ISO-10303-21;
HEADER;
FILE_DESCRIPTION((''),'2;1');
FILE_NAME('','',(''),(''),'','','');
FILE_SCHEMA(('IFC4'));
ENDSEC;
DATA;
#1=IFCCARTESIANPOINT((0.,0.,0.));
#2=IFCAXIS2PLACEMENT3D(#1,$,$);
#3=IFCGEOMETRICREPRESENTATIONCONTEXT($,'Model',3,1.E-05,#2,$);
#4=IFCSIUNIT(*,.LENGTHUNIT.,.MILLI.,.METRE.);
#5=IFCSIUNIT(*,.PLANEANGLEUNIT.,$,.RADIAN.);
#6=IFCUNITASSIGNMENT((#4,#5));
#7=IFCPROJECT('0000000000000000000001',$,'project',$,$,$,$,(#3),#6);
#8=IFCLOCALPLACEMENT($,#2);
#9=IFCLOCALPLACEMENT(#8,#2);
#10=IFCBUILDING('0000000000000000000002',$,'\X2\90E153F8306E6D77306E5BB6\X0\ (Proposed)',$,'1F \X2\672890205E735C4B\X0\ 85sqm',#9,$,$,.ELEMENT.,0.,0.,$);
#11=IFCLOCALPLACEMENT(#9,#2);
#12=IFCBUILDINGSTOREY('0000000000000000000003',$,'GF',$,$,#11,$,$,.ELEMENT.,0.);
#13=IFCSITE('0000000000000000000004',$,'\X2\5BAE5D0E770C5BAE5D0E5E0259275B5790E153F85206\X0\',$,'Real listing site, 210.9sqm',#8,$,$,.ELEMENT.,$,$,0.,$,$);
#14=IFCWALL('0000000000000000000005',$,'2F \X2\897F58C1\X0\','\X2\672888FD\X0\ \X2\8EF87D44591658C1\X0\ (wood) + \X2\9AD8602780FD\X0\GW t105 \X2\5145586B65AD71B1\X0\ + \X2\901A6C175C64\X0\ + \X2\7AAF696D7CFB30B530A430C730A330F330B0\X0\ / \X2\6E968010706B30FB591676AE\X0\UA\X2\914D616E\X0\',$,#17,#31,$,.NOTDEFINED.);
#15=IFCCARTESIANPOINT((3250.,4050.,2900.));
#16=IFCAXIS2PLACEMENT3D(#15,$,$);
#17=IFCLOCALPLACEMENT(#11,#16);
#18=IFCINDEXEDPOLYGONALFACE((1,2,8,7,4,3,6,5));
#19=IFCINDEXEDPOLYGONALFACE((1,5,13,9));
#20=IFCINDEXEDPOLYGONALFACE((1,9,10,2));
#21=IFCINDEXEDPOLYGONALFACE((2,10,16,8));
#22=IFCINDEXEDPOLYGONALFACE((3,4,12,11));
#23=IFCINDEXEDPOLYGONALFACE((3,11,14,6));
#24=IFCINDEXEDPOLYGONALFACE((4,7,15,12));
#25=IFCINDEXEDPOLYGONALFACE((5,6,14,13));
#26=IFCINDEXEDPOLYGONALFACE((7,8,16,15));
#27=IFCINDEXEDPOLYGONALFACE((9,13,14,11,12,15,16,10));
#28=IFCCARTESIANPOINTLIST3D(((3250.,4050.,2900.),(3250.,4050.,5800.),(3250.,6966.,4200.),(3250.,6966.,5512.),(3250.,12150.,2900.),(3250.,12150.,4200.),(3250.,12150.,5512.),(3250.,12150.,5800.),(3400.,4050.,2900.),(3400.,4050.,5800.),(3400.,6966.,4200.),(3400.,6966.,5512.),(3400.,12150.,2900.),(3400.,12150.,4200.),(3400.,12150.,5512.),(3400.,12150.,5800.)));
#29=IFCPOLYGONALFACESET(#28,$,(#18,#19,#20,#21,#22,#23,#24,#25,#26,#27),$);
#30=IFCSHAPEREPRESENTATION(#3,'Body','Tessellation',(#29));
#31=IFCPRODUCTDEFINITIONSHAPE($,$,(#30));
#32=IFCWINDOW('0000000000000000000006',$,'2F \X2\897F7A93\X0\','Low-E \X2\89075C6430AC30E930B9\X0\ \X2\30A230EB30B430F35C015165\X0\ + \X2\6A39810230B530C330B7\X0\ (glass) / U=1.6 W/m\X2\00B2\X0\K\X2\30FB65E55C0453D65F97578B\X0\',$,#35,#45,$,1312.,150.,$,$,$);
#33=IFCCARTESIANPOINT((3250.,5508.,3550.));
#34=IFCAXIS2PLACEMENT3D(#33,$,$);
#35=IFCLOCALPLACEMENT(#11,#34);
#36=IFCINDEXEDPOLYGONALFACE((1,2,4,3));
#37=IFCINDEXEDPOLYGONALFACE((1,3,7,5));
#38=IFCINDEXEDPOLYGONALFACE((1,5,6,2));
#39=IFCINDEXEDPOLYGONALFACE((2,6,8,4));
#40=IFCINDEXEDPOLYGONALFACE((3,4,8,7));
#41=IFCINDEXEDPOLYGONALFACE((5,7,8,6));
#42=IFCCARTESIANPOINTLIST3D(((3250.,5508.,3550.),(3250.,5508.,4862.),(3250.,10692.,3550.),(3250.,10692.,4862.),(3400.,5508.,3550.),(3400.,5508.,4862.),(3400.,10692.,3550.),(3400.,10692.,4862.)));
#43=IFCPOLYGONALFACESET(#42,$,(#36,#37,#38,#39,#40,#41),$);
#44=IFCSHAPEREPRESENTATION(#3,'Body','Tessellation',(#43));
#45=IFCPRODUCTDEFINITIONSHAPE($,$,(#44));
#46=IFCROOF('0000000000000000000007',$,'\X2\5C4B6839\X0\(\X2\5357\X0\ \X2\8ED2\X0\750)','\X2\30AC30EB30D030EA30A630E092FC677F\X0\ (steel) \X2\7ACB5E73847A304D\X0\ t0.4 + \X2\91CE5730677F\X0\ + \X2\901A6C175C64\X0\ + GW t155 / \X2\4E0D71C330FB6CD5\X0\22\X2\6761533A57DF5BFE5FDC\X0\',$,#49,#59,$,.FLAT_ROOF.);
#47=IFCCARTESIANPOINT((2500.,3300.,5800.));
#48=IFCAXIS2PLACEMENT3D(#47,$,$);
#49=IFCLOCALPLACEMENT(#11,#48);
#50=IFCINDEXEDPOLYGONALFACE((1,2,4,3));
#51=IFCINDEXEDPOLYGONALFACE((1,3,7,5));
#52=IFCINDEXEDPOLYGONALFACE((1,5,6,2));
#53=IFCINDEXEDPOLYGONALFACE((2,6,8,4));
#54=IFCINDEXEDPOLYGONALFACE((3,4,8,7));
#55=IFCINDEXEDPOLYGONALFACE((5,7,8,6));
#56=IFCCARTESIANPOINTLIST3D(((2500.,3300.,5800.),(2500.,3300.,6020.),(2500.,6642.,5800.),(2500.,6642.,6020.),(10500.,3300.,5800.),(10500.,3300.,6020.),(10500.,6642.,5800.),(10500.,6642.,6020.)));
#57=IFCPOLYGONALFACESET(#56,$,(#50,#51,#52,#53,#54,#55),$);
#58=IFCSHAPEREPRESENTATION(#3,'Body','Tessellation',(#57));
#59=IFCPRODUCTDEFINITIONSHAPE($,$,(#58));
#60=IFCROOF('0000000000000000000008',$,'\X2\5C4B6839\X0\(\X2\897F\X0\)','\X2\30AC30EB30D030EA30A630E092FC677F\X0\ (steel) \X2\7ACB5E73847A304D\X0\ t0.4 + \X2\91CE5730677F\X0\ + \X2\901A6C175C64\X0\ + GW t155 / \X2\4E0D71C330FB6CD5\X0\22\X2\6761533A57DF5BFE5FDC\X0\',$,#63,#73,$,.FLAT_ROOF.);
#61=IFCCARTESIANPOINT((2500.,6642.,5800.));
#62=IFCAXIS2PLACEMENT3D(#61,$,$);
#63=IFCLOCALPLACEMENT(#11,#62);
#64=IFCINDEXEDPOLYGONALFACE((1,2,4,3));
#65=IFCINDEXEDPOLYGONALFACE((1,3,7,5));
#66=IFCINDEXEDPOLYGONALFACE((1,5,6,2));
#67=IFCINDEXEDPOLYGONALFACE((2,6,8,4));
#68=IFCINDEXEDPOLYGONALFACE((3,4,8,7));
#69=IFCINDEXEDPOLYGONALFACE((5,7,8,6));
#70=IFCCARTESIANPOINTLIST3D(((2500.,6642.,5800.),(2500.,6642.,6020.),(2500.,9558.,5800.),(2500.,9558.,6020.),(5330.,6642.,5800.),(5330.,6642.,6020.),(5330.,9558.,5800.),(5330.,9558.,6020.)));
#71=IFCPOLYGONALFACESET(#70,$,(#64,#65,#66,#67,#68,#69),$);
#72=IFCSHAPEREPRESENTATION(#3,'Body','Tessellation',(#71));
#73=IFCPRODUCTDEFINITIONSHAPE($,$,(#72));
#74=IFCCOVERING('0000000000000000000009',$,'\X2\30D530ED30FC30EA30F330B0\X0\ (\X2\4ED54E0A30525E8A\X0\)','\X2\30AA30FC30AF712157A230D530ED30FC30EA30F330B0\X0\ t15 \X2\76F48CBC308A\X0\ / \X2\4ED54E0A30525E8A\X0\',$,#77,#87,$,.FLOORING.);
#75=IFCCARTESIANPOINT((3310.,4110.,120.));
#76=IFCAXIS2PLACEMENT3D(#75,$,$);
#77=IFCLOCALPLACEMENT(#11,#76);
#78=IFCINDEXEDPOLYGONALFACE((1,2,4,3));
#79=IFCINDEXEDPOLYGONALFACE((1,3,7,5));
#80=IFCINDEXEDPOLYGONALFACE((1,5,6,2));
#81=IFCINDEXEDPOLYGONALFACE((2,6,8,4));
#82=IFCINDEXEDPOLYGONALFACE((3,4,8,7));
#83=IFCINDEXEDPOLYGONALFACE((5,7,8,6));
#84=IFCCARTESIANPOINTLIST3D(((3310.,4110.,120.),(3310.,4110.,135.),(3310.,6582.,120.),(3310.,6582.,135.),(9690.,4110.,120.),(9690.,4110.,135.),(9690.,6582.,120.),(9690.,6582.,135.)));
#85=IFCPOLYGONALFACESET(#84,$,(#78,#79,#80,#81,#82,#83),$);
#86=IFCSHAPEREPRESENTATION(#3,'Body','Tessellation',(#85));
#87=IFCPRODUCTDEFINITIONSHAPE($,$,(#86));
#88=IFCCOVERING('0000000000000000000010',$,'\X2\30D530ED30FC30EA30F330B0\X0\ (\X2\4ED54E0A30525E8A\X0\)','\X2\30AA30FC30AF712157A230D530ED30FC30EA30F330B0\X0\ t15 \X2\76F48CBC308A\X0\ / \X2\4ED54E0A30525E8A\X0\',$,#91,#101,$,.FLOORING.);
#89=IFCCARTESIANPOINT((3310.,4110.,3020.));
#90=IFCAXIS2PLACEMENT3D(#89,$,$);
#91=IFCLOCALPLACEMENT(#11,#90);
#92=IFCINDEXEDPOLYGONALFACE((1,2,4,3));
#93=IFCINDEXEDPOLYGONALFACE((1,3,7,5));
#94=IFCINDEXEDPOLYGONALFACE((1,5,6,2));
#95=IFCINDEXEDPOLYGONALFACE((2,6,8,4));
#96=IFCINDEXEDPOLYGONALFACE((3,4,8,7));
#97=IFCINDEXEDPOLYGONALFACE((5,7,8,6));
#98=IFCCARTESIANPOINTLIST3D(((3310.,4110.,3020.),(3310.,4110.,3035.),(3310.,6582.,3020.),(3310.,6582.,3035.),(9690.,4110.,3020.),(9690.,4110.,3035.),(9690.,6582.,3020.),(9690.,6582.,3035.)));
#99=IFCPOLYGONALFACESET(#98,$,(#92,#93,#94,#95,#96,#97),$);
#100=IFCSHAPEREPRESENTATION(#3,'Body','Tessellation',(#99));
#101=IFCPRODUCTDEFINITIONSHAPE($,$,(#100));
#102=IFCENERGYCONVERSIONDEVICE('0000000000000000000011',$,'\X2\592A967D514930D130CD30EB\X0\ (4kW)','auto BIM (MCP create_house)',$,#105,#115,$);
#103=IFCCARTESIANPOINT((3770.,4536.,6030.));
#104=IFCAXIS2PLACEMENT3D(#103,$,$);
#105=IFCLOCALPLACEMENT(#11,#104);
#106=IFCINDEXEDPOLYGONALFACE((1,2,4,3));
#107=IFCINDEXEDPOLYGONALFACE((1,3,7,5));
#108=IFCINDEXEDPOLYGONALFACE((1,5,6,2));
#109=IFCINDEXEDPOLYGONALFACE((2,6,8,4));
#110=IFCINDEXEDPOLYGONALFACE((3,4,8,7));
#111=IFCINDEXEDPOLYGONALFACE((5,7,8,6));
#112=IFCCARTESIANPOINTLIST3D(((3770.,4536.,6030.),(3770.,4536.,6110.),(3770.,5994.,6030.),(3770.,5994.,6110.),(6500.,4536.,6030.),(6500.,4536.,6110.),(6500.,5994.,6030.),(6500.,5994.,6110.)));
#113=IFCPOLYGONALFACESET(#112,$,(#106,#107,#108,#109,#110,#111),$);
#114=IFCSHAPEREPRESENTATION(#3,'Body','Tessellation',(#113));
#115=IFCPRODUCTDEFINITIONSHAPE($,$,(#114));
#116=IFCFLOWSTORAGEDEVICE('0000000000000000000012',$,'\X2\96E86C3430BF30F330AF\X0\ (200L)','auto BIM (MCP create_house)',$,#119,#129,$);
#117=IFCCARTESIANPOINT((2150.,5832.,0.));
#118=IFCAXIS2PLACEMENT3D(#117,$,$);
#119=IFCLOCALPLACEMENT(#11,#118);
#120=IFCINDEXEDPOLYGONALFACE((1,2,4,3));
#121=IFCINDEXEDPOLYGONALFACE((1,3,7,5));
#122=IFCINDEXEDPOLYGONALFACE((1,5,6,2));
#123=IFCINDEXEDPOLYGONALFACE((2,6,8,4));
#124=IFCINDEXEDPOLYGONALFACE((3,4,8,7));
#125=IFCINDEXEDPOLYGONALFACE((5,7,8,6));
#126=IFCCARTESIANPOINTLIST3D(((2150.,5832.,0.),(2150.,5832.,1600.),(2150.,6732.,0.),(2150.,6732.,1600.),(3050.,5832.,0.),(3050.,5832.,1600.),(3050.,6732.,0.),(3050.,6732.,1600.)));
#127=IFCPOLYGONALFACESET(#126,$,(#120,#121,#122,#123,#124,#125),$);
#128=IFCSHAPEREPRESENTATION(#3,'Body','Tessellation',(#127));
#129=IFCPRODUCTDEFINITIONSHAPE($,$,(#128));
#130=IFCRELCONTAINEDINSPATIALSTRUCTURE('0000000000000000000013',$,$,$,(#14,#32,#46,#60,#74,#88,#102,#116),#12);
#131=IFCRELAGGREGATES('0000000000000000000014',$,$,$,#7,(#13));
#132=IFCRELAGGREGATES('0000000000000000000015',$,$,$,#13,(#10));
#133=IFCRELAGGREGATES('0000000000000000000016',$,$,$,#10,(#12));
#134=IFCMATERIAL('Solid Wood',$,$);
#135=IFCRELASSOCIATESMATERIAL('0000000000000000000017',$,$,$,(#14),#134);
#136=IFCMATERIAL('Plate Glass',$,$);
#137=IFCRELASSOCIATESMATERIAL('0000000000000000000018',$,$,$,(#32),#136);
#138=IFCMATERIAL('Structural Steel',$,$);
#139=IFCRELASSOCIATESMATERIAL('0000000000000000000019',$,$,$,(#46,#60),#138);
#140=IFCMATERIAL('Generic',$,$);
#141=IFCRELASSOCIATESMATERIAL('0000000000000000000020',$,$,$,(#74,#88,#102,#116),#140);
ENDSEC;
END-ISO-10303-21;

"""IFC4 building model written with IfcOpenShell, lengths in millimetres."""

from ifc_helpers import new_model, si_unit, frame, frame_2d, origin, place, context, project, spatial, rectangle, extrude, material, element, fill, save


model = new_model("IFC4")

# Units and contexts
model_context = context("Model", 3, precision=1e-05, world=origin())
ifc_project = project(units=[si_unit("LENGTHUNIT", "METRE", prefix="MILLI"), si_unit("PLANEANGLEUNIT", "RADIAN")], contexts=[model_context])

# Site, building, storey
site_placement = place(None, origin())
site = spatial("IfcSite", under=ifc_project, at=site_placement, Name="宮崎県宮崎市大字郡司分", ObjectType="Real listing site, 210.9sqm", CompositionType="ELEMENT", RefElevation=0.0)
building_placement = place(site_placement, origin())
building = spatial("IfcBuilding", under=site, at=building_placement, Name="郡司の海の家 (Proposed)", ObjectType="1F 木造平屋 85sqm", CompositionType="ELEMENT", ElevationOfRefHeight=0.0, ElevationOfTerrain=0.0)
storey_placement = place(building_placement, origin())
storey = spatial("IfcBuildingStorey", under=building, at=storey_placement, Name="GF", CompositionType="ELEMENT", Elevation=0.0)

# Shared definitions
ifc_material_1 = material(Name="Solid Wood")
ifc_material_2 = material(Name="Generic")

# Shared definitions
ifc_material_3 = material(Name="Plate Glass")

# Wall, opening, window
wall_1_placement = place(storey_placement, frame((3250.0, 4050.0, 2900.0)))
wall_1 = element("IfcWall", 1, at=wall_1_placement, inside=storey, material=ifc_material_1, Name="2F 西壁", Description="木製 軸組外壁 (wood) + 高性能GW t105 充填断熱 + 通気層 + 窯業系サイディング / 準耐火・外皮UA配慮", PredefinedType="NOTDEFINED", context=model_context, shape_type="SweptSolid", body=[
    extrude(rectangle(XDim=150.0, YDim=8100.0, at=frame_2d((75.0, 4050.0))), frame((3250.0, 4050.0, 2900.0)), (0.0, 0.0, 1.0), 2900.0),
])
opening_1_placement = place(storey_placement, frame((3250.0, 5508.0, 3550.0)))
opening_1 = element("IfcOpeningElement", 2, at=opening_1_placement, cuts=wall_1, PredefinedType="NOTDEFINED", context=model_context, shape_type="SweptSolid", body=[
    extrude(rectangle(XDim=150.0, YDim=5184.0, at=frame_2d((75.0, 2592.0))), frame((3250.0, 5508.0, 3550.0)), (0.0, 0.0, 1.0), 1312.0),
])
window_1_placement = place(storey_placement, frame((3250.0, 5508.0, 3550.0)))
window_1 = element("IfcWindow", 3, at=window_1_placement, inside=storey, material=ifc_material_3, Name="2F 西窓", Description="Low-E 複層ガラス アルゴン封入 + 樹脂サッシ (glass) / U=1.6 W/m²K・日射取得型", OverallHeight=1312.0, OverallWidth=150.0, context=model_context, shape_type="SweptSolid", body=[
    extrude(rectangle(XDim=150.0, YDim=5184.0, at=frame_2d((75.0, 2592.0))), frame((3250.0, 5508.0, 3550.0)), (0.0, 0.0, 1.0), 1312.0),
])
fill(opening_1, window_1)

# Roofs
ifc_material_4 = material(Name="Structural Steel")
roof_1_placement = place(storey_placement, frame((2500.0, 3300.0, 5800.0)))
element("IfcRoof", 4, at=roof_1_placement, inside=storey, material=ifc_material_4, Name="屋根(南 軒750)", Description="ガルバリウム鋼板 (steel) 立平葺き t0.4 + 野地板 + 通気層 + GW t155 / 不燃・法22条区域対応", PredefinedType="FLAT_ROOF", context=model_context, shape_type="SweptSolid", body=[
    extrude(rectangle(XDim=8000.0, YDim=3342.0, at=frame_2d((4000.0, 1671.0))), frame((2500.0, 3300.0, 5800.0)), (0.0, 0.0, 1.0), 220.0),
])
roof_2_placement = place(storey_placement, frame((2500.0, 6642.0, 5800.0)))
element("IfcRoof", 5, at=roof_2_placement, inside=storey, material=ifc_material_4, Name="屋根(西)", Description="ガルバリウム鋼板 (steel) 立平葺き t0.4 + 野地板 + 通気層 + GW t155 / 不燃・法22条区域対応", PredefinedType="FLAT_ROOF", context=model_context, shape_type="SweptSolid", body=[
    extrude(rectangle(XDim=2830.0, YDim=2916.0, at=frame_2d((1415.0, 1458.0))), frame((2500.0, 6642.0, 5800.0)), (0.0, 0.0, 1.0), 220.0),
])

# Coverings
covering_1_placement = place(storey_placement, frame((3310.0, 4110.0, 120.0)))
element("IfcCovering", 6, at=covering_1_placement, inside=storey, material=ifc_material_2, Name="フローリング (仕上げ床)", Description="オーク無垢フローリング t15 直貼り / 仕上げ床", PredefinedType="FLOORING", context=model_context, shape_type="SweptSolid", body=[
    extrude(rectangle(XDim=6380.0, YDim=2472.0, at=frame_2d((3190.0, 1236.0))), frame((3310.0, 4110.0, 120.0)), (0.0, 0.0, 1.0), 15.0),
])
covering_2_placement = place(storey_placement, frame((3310.0, 4110.0, 3020.0)))
element("IfcCovering", 7, at=covering_2_placement, inside=storey, material=ifc_material_2, Name="フローリング (仕上げ床)", Description="オーク無垢フローリング t15 直貼り / 仕上げ床", PredefinedType="FLOORING", context=model_context, shape_type="SweptSolid", body=[
    extrude(rectangle(XDim=6380.0, YDim=2472.0, at=frame_2d((3190.0, 1236.0))), frame((3310.0, 4110.0, 3020.0)), (0.0, 0.0, 1.0), 15.0),
])

# Energy conversion device
energy_conversion_device_placement = place(storey_placement, frame((3770.0, 4536.0, 6030.0)))
element("IfcEnergyConversionDevice", 8, at=energy_conversion_device_placement, inside=storey, material=ifc_material_2, Name="太陽光パネル (4kW)", Description="auto BIM (MCP create_house)", context=model_context, shape_type="SweptSolid", body=[
    extrude(rectangle(XDim=2730.0, YDim=1458.0, at=frame_2d((1365.0, 729.0))), frame((3770.0, 4536.0, 6030.0)), (0.0, 0.0, 1.0), 80.0),
])

# Flow storage device
flow_storage_device_placement = place(storey_placement, frame((2150.0, 5832.0, 0.0)))
element("IfcFlowStorageDevice", 9, at=flow_storage_device_placement, inside=storey, material=ifc_material_2, Name="雨水タンク (200L)", Description="auto BIM (MCP create_house)", context=model_context, shape_type="SweptSolid", body=[
    extrude(rectangle(XDim=900.0, YDim=900.0, at=frame_2d((450.0, 450.0))), frame((2150.0, 5832.0, 0.0)), (0.0, 0.0, 1.0), 1600.0),
])

save(model, "model.ifc")
